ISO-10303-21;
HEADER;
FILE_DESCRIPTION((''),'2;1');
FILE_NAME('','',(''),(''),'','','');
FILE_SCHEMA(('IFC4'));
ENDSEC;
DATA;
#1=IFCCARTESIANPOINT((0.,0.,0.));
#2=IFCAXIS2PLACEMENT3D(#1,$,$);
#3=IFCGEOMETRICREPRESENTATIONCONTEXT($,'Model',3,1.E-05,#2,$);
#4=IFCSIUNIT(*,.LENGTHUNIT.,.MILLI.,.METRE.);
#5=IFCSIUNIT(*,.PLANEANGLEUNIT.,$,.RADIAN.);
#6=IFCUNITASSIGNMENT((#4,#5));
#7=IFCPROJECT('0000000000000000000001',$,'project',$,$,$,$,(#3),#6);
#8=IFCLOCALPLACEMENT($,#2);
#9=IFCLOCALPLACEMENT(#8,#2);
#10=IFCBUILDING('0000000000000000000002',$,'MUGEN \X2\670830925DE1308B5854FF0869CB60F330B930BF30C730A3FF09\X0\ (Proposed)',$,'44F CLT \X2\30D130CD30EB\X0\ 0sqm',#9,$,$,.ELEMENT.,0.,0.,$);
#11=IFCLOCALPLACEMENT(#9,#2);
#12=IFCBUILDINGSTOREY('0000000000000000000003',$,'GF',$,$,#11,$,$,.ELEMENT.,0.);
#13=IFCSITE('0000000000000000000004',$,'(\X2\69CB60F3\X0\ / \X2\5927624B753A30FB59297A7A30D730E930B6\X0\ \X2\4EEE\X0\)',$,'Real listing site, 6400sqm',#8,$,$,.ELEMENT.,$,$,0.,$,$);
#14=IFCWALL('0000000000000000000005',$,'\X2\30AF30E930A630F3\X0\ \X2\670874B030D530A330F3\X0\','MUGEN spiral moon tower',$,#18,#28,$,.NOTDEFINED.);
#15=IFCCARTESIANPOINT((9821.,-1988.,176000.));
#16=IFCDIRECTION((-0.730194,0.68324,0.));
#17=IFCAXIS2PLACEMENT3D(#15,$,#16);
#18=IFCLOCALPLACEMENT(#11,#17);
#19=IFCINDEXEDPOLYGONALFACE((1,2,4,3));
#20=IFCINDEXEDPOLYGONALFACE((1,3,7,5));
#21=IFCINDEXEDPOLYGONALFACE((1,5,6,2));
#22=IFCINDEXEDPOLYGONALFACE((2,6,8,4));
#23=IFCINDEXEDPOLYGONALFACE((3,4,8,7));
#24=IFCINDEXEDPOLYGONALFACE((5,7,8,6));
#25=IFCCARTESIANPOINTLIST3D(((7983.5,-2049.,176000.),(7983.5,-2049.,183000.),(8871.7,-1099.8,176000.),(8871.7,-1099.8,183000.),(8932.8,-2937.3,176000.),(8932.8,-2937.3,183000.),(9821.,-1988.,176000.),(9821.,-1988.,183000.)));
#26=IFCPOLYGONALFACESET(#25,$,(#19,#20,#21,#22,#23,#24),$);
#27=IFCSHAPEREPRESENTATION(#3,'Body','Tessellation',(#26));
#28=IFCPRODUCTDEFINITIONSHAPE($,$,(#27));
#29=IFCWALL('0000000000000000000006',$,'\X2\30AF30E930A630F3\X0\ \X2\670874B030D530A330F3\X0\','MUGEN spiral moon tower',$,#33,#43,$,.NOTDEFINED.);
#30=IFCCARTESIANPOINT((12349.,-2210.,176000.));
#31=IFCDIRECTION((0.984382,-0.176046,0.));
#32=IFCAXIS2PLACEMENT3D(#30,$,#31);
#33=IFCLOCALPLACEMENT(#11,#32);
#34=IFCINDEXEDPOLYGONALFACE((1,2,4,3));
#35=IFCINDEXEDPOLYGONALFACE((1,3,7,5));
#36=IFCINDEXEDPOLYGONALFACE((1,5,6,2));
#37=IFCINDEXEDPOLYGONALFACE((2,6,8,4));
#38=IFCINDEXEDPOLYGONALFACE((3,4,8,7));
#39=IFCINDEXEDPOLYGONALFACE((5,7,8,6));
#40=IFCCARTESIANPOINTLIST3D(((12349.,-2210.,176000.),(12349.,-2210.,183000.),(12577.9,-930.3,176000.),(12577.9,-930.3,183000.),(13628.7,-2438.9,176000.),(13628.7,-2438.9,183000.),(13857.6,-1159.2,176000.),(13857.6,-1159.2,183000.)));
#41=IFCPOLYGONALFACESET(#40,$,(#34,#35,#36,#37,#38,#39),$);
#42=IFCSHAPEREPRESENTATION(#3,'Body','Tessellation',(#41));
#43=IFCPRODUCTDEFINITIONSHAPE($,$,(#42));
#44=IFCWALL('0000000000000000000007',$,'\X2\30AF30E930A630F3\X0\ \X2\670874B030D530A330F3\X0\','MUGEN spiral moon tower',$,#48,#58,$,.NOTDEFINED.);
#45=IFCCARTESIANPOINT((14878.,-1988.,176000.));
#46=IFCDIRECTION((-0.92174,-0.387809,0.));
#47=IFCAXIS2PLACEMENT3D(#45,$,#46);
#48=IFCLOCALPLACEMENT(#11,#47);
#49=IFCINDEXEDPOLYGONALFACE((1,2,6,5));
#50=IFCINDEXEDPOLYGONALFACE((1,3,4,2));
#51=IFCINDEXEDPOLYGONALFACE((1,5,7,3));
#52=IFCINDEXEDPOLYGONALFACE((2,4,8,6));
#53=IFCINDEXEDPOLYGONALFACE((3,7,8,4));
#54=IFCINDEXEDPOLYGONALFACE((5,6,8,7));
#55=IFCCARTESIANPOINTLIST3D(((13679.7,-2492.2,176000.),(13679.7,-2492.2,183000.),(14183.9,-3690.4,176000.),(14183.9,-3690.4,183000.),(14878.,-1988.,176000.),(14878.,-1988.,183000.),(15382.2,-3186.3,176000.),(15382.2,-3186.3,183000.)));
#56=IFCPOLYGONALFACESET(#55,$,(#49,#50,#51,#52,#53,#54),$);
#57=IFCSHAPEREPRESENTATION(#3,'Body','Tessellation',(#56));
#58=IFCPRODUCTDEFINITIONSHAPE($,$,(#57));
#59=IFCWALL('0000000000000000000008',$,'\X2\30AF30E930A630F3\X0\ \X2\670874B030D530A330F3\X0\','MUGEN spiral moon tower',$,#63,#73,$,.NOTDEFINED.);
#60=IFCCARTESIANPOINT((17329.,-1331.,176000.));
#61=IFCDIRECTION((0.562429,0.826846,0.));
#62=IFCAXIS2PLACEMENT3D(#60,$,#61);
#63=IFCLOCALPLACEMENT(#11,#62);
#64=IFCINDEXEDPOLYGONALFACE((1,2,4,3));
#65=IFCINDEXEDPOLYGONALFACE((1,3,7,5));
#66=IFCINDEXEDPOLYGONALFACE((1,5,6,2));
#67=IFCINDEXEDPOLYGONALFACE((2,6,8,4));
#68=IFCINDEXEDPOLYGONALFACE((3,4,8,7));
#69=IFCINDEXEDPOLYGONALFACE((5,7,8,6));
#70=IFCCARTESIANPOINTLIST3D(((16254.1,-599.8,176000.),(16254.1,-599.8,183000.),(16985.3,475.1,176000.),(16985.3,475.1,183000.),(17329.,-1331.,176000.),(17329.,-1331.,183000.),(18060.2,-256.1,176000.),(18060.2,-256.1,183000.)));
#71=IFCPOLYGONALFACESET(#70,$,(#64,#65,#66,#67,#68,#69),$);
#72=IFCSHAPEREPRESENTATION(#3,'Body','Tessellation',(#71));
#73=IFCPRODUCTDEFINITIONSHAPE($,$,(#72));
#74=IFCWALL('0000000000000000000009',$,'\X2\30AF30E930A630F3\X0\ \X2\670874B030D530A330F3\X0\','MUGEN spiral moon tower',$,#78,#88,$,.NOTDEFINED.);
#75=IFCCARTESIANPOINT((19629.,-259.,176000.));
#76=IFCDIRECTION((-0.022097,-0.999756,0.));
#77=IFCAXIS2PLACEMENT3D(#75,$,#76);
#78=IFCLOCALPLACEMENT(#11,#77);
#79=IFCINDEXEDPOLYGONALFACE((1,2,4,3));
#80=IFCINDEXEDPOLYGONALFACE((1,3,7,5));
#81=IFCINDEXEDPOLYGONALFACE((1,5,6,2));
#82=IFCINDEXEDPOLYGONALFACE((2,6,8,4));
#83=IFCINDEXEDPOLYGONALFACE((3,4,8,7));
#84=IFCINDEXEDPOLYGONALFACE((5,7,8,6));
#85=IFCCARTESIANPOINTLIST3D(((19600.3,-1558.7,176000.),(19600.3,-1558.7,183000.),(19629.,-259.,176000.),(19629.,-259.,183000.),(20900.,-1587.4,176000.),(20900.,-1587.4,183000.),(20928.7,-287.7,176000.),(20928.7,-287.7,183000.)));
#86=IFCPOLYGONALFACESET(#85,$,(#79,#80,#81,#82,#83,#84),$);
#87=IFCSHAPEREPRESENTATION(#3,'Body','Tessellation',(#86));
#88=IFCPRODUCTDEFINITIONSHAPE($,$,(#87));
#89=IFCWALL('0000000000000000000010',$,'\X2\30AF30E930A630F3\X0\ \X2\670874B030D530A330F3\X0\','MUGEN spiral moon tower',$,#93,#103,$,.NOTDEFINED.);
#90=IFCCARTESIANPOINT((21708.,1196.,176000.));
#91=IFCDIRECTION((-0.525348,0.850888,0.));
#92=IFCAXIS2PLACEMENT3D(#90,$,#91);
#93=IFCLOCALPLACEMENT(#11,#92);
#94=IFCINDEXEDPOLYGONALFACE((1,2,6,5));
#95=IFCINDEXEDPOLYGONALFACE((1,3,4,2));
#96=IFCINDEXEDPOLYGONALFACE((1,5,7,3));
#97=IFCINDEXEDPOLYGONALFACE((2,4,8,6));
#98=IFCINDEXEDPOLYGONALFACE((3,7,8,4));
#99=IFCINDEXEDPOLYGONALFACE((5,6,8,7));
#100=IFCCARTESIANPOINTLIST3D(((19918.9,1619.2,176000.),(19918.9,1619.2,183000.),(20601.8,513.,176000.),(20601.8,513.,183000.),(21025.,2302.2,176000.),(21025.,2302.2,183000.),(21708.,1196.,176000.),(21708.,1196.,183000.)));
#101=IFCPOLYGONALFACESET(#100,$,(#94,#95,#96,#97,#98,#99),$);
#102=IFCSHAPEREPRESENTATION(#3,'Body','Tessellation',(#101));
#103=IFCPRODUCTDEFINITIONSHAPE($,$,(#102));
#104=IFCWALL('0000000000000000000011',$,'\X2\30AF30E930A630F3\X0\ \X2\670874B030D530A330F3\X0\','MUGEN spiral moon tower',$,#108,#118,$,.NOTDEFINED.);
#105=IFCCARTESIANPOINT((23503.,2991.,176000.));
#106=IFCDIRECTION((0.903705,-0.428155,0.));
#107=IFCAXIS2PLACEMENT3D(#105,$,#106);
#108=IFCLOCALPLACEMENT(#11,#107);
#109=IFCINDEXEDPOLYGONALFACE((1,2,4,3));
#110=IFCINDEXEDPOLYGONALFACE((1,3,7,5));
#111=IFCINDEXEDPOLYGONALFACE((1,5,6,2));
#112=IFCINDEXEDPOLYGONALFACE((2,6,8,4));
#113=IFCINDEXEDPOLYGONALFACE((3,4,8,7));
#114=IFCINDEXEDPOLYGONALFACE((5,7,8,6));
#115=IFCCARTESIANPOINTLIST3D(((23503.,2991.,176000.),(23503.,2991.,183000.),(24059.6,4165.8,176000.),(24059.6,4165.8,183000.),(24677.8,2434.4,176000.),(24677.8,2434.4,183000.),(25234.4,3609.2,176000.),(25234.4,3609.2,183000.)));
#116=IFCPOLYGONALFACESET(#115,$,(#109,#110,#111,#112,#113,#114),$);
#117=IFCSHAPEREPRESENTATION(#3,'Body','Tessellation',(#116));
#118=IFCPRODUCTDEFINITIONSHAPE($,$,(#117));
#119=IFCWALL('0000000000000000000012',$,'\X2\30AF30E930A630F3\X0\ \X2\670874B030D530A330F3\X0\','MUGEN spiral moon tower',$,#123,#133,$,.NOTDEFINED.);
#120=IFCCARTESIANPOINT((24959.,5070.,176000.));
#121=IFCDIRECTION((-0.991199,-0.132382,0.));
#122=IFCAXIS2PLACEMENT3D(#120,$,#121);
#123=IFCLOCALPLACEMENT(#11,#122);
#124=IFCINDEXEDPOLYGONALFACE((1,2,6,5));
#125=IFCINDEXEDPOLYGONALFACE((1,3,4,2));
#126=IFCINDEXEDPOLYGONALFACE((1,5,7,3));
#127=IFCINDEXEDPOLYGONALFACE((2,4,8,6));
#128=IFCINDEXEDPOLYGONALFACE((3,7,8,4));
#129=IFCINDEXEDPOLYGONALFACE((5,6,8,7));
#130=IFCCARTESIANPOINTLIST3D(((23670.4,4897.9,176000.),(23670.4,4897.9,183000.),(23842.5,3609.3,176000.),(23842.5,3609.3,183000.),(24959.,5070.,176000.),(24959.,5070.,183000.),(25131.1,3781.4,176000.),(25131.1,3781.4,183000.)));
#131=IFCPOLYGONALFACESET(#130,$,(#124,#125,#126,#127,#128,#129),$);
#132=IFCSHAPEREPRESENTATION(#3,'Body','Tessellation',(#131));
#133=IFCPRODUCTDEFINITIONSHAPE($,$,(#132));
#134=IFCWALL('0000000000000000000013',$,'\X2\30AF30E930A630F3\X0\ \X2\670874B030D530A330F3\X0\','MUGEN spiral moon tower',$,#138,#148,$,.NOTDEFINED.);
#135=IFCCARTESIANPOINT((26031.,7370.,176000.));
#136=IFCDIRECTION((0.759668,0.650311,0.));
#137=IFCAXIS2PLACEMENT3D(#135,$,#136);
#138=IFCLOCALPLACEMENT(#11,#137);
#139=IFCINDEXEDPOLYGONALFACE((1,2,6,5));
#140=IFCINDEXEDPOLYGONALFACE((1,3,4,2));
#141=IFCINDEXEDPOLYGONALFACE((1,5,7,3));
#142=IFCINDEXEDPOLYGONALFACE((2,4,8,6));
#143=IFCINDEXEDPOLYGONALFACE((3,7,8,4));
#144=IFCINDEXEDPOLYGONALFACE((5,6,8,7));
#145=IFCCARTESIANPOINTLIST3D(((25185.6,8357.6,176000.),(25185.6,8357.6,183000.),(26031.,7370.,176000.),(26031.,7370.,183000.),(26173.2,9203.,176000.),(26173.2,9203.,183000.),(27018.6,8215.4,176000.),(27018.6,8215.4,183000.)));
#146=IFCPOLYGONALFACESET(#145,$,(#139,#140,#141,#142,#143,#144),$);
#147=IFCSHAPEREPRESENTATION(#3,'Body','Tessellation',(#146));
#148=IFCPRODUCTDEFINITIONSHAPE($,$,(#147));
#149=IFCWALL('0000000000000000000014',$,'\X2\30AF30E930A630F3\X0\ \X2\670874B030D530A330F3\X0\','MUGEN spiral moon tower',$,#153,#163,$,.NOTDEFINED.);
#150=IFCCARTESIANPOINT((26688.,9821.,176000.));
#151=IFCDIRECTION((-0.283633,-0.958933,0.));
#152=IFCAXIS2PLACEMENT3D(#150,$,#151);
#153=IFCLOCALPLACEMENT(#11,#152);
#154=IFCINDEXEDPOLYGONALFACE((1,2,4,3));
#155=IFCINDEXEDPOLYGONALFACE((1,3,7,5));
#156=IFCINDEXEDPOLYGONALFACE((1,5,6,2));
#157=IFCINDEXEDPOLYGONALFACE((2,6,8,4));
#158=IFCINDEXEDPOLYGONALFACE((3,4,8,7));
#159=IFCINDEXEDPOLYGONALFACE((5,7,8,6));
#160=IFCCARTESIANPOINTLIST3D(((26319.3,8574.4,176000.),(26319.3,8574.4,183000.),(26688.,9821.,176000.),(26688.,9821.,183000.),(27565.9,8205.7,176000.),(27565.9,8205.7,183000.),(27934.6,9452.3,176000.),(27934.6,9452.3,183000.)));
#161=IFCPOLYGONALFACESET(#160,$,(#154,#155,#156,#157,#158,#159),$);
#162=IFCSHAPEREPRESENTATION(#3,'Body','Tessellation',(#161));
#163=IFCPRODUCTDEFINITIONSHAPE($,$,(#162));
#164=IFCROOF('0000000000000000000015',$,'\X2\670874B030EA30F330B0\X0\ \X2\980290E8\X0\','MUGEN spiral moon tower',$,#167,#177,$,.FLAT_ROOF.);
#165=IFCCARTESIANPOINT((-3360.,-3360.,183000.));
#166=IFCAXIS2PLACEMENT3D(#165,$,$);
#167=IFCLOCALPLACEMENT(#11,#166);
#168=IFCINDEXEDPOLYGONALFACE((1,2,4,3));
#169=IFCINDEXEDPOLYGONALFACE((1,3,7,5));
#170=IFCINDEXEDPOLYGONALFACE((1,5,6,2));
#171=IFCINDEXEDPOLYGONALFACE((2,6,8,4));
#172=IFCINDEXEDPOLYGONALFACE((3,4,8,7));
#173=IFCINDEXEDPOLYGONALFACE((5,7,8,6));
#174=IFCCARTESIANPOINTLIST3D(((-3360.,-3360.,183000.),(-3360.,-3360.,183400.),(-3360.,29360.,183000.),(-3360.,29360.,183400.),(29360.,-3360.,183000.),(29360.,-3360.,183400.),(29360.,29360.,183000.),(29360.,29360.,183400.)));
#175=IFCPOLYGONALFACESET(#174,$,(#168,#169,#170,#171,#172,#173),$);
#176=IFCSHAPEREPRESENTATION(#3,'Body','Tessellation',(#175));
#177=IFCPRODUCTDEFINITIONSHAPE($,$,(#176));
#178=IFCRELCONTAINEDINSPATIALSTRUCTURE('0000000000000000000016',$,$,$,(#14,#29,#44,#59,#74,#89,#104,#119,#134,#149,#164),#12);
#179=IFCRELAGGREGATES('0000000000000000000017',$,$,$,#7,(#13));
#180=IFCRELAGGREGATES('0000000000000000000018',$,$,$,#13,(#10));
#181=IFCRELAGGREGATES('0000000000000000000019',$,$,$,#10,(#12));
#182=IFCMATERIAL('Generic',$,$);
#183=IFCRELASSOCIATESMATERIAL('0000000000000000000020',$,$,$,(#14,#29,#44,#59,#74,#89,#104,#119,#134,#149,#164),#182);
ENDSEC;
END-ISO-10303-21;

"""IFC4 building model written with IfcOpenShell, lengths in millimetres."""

from ifc_helpers import new_model, si_unit, frame, frame_2d, origin, place, context, project, spatial, rectangle, extrude, material, element, save


model = new_model("IFC4")

# Units and contexts
model_context = context("Model", 3, precision=1e-05, world=origin())
ifc_project = project(units=[si_unit("LENGTHUNIT", "METRE", prefix="MILLI"), si_unit("PLANEANGLEUNIT", "RADIAN")], contexts=[model_context])

# Site, building, storey
site_placement = place(None, origin())
site = spatial("IfcSite", under=ifc_project, at=site_placement, Name="(構想 / 大手町・天空プラザ 仮)", ObjectType="Real listing site, 6400sqm", CompositionType="ELEMENT", RefElevation=0.0)
building_placement = place(site_placement, origin())
building = spatial("IfcBuilding", under=site, at=building_placement, Name="MUGEN 月を巡る塔（構想スタディ） (Proposed)", ObjectType="44F CLT パネル 0sqm", CompositionType="ELEMENT", ElevationOfRefHeight=0.0, ElevationOfTerrain=0.0)
storey_placement = place(building_placement, origin())
storey = spatial("IfcBuildingStorey", under=building, at=storey_placement, Name="GF", CompositionType="ELEMENT", Elevation=0.0)

# Shared definitions
ifc_material = material(Name="Generic")

# Walls
wall_1_placement = place(storey_placement, frame((9821.0, -1988.0, 176000.0), x_axis=(-0.730194, 0.68324, 0.0)))
element("IfcWall", 1, at=wall_1_placement, inside=storey, material=ifc_material, Name="クラウン 月環フィン", Description="MUGEN spiral moon tower", PredefinedType="NOTDEFINED", context=model_context, shape_type="SweptSolid", body=[
    extrude(rectangle(XDim=1300.0, YDim=1300.0, at=frame_2d((650.0, 650.0))), frame((9821.0, -1988.0, 176000.0), x_axis=(-0.730194, 0.68324, 0.0)), (0.0, 0.0, 1.0), 7000.0),
])
wall_2_placement = place(storey_placement, frame((12349.0, -2210.0, 176000.0), x_axis=(0.984382, -0.176046, 0.0)))
element("IfcWall", 2, at=wall_2_placement, inside=storey, material=ifc_material, Name="クラウン 月環フィン", Description="MUGEN spiral moon tower", PredefinedType="NOTDEFINED", context=model_context, shape_type="SweptSolid", body=[
    extrude(rectangle(XDim=1300.0, YDim=1300.0, at=frame_2d((650.0, 650.0))), frame((12349.0, -2210.0, 176000.0), x_axis=(0.984382, -0.176046, 0.0)), (0.0, 0.0, 1.0), 7000.0),
])
wall_3_placement = place(storey_placement, frame((14878.0, -1988.0, 176000.0), x_axis=(-0.92174, -0.387809, 0.0)))
element("IfcWall", 3, at=wall_3_placement, inside=storey, material=ifc_material, Name="クラウン 月環フィン", Description="MUGEN spiral moon tower", PredefinedType="NOTDEFINED", context=model_context, shape_type="SweptSolid", body=[
    extrude(rectangle(XDim=1300.0, YDim=1300.0, at=frame_2d((650.0, 650.0))), frame((14878.0, -1988.0, 176000.0), x_axis=(-0.92174, -0.387809, 0.0)), (0.0, 0.0, 1.0), 7000.0),
])
wall_4_placement = place(storey_placement, frame((17329.0, -1331.0, 176000.0), x_axis=(0.562429, 0.826846, 0.0)))
element("IfcWall", 4, at=wall_4_placement, inside=storey, material=ifc_material, Name="クラウン 月環フィン", Description="MUGEN spiral moon tower", PredefinedType="NOTDEFINED", context=model_context, shape_type="SweptSolid", body=[
    extrude(rectangle(XDim=1300.0, YDim=1300.0, at=frame_2d((650.0, 650.0))), frame((17329.0, -1331.0, 176000.0), x_axis=(0.562429, 0.826846, 0.0)), (0.0, 0.0, 1.0), 7000.0),
])
wall_5_placement = place(storey_placement, frame((19629.0, -259.0, 176000.0), x_axis=(-0.022097, -0.999756, 0.0)))
element("IfcWall", 5, at=wall_5_placement, inside=storey, material=ifc_material, Name="クラウン 月環フィン", Description="MUGEN spiral moon tower", PredefinedType="NOTDEFINED", context=model_context, shape_type="SweptSolid", body=[
    extrude(rectangle(XDim=1300.0, YDim=1300.0, at=frame_2d((650.0, 650.0))), frame((19629.0, -259.0, 176000.0), x_axis=(-0.022097, -0.999756, 0.0)), (0.0, 0.0, 1.0), 7000.0),
])
wall_6_placement = place(storey_placement, frame((21708.0, 1196.0, 176000.0), x_axis=(-0.525348, 0.850888, 0.0)))
element("IfcWall", 6, at=wall_6_placement, inside=storey, material=ifc_material, Name="クラウン 月環フィン", Description="MUGEN spiral moon tower", PredefinedType="NOTDEFINED", context=model_context, shape_type="SweptSolid", body=[
    extrude(rectangle(XDim=1300.0, YDim=1300.0, at=frame_2d((650.0, 650.0))), frame((21708.0, 1196.0, 176000.0), x_axis=(-0.525348, 0.850888, 0.0)), (0.0, 0.0, 1.0), 7000.0),
])
wall_7_placement = place(storey_placement, frame((23503.0, 2991.0, 176000.0), x_axis=(0.903705, -0.428155, 0.0)))
element("IfcWall", 7, at=wall_7_placement, inside=storey, material=ifc_material, Name="クラウン 月環フィン", Description="MUGEN spiral moon tower", PredefinedType="NOTDEFINED", context=model_context, shape_type="SweptSolid", body=[
    extrude(rectangle(XDim=1300.0, YDim=1300.0, at=frame_2d((650.0, 650.0))), frame((23503.0, 2991.0, 176000.0), x_axis=(0.903705, -0.428155, 0.0)), (0.0, 0.0, 1.0), 7000.0),
])
wall_8_placement = place(storey_placement, frame((24959.0, 5070.0, 176000.0), x_axis=(-0.991199, -0.132382, 0.0)))
element("IfcWall", 8, at=wall_8_placement, inside=storey, material=ifc_material, Name="クラウン 月環フィン", Description="MUGEN spiral moon tower", PredefinedType="NOTDEFINED", context=model_context, shape_type="SweptSolid", body=[
    extrude(rectangle(XDim=1300.0, YDim=1300.0, at=frame_2d((650.0, 650.0))), frame((24959.0, 5070.0, 176000.0), x_axis=(-0.991199, -0.132382, 0.0)), (0.0, 0.0, 1.0), 7000.0),
])
wall_9_placement = place(storey_placement, frame((26031.0, 7370.0, 176000.0), x_axis=(0.759668, 0.650311, 0.0)))
element("IfcWall", 9, at=wall_9_placement, inside=storey, material=ifc_material, Name="クラウン 月環フィン", Description="MUGEN spiral moon tower", PredefinedType="NOTDEFINED", context=model_context, shape_type="SweptSolid", body=[
    extrude(rectangle(XDim=1300.0, YDim=1300.0, at=frame_2d((650.0, 650.0))), frame((26031.0, 7370.0, 176000.0), x_axis=(0.759668, 0.650311, 0.0)), (0.0, 0.0, 1.0), 7000.0),
])
wall_10_placement = place(storey_placement, frame((26688.0, 9821.0, 176000.0), x_axis=(-0.283633, -0.958933, 0.0)))
element("IfcWall", 10, at=wall_10_placement, inside=storey, material=ifc_material, Name="クラウン 月環フィン", Description="MUGEN spiral moon tower", PredefinedType="NOTDEFINED", context=model_context, shape_type="SweptSolid", body=[
    extrude(rectangle(XDim=1300.0, YDim=1300.0, at=frame_2d((650.0, 650.0))), frame((26688.0, 9821.0, 176000.0), x_axis=(-0.283633, -0.958933, 0.0)), (0.0, 0.0, 1.0), 7000.0),
])

# Roof
roof_placement = place(storey_placement, frame((-3360.0, -3360.0, 183000.0)))
element("IfcRoof", 11, at=roof_placement, inside=storey, material=ifc_material, Name="月環リング 頂部", Description="MUGEN spiral moon tower", PredefinedType="FLAT_ROOF", context=model_context, shape_type="SweptSolid", body=[
    extrude(rectangle(XDim=32720.0, YDim=32720.0, at=frame_2d((16360.0, 16360.0))), frame((-3360.0, -3360.0, 183000.0)), (0.0, 0.0, 1.0), 400.0),
])

save(model, "model.ifc")
